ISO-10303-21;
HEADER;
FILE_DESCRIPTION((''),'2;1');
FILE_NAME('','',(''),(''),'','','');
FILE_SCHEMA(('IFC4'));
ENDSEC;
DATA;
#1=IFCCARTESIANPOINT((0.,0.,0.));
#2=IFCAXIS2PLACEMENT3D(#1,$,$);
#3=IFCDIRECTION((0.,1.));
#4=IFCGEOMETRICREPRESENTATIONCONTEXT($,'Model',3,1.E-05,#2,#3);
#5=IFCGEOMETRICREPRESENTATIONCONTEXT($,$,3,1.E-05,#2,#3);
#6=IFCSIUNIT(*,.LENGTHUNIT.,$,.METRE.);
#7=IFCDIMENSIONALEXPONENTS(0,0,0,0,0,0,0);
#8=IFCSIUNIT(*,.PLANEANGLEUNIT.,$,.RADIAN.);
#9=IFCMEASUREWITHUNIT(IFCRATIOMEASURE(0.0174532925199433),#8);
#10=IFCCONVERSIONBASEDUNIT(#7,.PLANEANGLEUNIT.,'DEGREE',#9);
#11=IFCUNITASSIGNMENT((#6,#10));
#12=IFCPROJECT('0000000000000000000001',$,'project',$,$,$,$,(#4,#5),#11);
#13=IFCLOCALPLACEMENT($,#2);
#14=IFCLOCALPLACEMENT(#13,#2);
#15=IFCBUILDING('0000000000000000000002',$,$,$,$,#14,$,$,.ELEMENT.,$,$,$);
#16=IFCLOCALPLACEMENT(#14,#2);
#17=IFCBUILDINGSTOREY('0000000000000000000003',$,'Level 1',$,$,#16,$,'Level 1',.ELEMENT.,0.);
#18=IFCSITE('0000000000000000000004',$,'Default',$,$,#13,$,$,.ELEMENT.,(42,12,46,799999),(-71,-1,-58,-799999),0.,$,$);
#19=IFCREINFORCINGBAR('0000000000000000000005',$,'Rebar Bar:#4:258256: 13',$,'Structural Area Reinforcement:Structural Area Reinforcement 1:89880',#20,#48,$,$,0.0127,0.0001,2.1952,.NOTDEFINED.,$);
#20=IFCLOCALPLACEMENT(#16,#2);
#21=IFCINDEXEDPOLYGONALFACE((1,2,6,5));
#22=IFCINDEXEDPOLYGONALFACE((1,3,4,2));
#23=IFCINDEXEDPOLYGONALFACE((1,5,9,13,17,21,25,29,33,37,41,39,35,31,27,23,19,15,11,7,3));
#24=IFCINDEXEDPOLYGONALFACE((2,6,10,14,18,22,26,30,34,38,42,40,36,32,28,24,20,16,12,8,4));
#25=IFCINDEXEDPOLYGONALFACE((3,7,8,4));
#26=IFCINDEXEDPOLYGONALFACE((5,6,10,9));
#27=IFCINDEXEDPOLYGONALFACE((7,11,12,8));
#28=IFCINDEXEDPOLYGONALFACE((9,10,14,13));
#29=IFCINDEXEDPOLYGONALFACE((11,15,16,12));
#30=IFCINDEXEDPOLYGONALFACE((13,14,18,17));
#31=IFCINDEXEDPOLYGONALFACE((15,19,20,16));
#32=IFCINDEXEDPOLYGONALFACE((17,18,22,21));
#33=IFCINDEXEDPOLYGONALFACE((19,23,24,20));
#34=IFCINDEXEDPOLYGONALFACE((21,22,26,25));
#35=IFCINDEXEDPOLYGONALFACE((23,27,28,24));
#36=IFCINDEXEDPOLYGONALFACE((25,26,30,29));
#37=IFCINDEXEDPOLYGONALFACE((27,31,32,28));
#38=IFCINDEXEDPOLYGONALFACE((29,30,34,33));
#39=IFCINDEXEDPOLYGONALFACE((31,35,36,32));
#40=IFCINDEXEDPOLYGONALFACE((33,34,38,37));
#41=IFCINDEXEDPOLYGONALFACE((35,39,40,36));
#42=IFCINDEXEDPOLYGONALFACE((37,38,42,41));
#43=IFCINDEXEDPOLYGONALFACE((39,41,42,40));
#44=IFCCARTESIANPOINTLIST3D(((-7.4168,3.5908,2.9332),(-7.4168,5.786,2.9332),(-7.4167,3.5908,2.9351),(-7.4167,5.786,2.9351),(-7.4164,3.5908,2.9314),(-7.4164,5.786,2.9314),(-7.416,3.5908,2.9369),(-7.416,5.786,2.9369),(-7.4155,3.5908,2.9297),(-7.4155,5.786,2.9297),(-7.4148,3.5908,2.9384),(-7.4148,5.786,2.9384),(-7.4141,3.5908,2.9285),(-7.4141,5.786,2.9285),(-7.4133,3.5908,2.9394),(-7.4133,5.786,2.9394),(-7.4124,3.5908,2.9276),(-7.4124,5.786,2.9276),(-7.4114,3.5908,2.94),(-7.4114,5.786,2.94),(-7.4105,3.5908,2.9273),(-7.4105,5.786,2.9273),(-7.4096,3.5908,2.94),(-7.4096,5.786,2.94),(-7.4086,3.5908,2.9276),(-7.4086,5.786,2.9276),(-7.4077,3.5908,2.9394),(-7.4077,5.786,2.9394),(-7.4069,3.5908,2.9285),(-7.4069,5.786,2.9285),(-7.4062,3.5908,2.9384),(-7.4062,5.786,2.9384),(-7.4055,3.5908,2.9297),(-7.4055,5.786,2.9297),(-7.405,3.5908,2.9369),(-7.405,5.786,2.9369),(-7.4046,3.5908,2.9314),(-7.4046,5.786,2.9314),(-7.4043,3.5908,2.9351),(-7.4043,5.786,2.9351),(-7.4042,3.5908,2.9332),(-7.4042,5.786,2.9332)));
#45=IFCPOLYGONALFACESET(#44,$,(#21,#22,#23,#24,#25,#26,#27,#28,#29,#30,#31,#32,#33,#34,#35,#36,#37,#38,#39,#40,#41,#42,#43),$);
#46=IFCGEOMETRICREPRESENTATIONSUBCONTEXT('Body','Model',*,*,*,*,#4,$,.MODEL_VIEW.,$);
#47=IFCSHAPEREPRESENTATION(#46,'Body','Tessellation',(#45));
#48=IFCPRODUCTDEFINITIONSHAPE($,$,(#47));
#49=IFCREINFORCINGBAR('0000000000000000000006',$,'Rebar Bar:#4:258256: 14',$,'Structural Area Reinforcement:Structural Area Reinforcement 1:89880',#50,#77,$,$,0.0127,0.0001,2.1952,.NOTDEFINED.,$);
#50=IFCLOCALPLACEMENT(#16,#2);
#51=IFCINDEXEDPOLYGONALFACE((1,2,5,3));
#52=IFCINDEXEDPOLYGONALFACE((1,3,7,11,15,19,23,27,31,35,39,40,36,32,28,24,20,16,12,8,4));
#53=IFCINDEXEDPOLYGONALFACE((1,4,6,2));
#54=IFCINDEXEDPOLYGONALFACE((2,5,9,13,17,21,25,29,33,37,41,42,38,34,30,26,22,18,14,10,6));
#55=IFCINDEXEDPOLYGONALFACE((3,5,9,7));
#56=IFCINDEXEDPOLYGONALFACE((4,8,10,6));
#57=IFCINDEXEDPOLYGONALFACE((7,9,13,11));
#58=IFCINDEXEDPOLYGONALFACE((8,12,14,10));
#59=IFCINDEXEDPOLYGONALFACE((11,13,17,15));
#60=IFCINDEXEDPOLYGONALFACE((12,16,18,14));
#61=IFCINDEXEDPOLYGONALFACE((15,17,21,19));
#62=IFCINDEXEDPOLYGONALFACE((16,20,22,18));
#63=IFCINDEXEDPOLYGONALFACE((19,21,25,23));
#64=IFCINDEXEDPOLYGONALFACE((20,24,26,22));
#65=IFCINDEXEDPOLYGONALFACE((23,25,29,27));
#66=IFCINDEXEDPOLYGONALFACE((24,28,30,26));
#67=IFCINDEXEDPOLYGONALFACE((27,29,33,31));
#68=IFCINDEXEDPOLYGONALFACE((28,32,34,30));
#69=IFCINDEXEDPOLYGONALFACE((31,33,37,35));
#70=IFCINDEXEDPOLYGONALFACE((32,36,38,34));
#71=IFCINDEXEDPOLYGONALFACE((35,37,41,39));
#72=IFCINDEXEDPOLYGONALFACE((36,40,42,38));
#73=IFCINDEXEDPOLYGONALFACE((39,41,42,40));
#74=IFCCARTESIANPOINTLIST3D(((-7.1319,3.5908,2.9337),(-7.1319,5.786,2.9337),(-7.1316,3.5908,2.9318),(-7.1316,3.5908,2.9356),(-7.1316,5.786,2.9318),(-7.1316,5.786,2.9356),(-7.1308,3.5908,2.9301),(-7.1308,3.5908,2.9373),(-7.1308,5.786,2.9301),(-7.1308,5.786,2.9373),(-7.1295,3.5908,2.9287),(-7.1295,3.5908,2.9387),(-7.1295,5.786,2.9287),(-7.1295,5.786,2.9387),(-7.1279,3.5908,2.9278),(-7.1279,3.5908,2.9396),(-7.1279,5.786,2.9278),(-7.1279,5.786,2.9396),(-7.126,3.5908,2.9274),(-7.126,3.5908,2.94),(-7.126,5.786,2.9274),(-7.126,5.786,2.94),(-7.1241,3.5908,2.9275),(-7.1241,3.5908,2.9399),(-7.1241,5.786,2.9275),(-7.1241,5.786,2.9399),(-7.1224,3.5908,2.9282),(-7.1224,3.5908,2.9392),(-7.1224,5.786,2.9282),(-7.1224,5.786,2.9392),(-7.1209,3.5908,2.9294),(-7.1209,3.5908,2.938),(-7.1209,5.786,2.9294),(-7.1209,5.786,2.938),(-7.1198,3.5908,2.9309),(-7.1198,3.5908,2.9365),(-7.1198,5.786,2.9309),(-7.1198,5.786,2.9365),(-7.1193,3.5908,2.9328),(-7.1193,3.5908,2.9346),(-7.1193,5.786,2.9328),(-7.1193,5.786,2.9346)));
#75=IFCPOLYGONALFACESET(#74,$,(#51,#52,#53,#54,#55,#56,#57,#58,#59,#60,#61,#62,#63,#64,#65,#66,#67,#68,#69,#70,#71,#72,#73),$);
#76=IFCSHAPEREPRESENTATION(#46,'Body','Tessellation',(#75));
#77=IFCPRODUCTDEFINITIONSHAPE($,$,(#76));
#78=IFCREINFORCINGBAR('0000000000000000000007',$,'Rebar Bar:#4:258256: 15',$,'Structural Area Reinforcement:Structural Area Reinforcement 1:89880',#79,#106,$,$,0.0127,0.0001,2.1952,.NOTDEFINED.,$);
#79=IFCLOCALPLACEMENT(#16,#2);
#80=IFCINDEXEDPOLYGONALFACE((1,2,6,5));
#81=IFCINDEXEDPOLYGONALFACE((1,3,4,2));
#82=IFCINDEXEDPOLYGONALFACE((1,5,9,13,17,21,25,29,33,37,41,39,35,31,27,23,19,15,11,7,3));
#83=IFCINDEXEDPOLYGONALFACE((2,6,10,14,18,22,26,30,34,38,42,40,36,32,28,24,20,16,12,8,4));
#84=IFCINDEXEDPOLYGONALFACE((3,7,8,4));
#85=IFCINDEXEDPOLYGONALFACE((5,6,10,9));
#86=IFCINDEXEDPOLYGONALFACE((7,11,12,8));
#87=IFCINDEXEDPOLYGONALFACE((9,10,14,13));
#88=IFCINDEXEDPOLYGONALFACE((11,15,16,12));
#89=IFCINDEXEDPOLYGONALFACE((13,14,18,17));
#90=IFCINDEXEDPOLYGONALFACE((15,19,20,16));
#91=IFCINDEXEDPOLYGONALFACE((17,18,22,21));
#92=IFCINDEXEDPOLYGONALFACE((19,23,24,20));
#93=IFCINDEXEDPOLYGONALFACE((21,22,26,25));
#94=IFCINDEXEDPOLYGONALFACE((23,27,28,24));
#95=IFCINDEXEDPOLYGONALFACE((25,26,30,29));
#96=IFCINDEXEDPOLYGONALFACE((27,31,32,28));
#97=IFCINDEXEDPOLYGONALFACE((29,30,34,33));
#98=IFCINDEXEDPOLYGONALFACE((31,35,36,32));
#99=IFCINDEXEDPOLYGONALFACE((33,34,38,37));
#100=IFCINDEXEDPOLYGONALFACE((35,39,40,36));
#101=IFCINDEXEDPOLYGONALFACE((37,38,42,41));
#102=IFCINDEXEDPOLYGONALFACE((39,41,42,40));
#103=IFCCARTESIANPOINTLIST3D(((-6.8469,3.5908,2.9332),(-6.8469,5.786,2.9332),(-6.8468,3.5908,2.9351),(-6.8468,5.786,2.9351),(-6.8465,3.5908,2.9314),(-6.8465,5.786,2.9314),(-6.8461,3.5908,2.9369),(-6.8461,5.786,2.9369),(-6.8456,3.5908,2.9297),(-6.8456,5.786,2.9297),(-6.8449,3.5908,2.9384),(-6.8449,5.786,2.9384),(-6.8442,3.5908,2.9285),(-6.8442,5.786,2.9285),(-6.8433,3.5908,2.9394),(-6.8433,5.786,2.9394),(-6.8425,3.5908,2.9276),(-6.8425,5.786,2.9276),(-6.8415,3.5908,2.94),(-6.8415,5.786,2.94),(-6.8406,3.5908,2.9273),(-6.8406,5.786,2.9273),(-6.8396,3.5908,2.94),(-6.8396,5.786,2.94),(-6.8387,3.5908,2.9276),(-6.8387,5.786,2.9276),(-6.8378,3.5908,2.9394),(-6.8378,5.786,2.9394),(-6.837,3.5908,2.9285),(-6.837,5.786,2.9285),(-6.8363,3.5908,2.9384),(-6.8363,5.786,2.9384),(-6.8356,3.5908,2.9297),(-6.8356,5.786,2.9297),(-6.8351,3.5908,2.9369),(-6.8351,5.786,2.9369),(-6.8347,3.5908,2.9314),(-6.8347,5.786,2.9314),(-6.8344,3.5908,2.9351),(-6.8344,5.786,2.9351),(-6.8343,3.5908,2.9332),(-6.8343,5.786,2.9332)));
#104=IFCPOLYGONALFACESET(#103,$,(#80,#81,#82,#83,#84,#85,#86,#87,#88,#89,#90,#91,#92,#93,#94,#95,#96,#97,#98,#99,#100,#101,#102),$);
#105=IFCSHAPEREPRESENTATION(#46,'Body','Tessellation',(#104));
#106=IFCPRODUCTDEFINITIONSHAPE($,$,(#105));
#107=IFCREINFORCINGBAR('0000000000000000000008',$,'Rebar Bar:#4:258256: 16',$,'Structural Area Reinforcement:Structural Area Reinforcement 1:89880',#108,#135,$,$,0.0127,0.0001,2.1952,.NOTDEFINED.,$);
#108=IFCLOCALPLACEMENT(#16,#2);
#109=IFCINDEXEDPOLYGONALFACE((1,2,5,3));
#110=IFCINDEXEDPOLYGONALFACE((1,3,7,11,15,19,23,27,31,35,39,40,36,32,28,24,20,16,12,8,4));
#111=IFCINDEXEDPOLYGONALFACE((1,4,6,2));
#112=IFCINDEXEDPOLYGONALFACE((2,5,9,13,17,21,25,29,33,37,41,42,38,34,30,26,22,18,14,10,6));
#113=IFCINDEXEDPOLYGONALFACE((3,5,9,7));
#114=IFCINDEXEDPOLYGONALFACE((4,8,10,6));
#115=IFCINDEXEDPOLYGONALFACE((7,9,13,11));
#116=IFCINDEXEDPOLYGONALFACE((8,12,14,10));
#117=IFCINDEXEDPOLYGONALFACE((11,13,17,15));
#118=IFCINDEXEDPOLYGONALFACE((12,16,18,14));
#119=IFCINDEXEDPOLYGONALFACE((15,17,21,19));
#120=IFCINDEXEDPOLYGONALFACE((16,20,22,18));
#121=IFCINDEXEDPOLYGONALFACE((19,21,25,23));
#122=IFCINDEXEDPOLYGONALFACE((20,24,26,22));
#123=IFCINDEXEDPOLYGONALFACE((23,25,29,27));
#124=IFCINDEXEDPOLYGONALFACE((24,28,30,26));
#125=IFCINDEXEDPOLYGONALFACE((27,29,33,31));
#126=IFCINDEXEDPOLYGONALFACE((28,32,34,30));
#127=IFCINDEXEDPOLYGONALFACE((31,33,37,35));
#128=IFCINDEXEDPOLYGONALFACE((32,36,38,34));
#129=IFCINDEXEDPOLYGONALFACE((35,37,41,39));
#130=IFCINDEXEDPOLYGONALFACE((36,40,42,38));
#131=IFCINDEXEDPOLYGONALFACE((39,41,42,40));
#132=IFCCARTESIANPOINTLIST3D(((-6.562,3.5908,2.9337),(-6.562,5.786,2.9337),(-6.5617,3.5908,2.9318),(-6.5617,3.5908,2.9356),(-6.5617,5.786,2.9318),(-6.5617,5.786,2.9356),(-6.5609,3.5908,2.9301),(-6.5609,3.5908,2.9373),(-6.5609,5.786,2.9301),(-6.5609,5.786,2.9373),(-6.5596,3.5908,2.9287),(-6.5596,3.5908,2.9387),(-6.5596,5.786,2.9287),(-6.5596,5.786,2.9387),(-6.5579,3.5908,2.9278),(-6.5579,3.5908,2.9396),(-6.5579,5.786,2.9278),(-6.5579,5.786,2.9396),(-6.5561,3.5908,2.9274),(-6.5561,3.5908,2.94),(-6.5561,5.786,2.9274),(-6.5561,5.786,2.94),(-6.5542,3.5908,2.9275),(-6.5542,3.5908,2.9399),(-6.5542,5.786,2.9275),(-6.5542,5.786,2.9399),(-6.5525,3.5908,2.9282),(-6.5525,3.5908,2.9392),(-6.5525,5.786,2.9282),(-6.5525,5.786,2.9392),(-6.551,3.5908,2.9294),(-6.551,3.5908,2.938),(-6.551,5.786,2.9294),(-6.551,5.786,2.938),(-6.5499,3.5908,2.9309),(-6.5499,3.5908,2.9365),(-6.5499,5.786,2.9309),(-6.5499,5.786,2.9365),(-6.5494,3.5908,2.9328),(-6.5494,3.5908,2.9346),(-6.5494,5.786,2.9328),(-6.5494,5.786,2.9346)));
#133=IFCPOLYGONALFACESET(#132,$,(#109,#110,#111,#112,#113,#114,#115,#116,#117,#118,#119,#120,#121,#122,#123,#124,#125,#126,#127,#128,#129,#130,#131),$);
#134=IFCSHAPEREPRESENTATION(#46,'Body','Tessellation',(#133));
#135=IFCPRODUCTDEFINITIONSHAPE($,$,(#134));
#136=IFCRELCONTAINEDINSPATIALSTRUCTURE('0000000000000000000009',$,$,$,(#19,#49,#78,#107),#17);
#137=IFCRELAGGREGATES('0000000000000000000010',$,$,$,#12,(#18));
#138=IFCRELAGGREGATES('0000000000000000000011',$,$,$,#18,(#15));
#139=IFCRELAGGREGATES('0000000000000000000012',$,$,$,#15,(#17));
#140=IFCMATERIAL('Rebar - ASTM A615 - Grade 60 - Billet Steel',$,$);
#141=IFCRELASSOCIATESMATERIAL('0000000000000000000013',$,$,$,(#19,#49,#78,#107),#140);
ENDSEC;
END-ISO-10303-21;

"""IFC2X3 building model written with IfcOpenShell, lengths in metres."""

from ifc_helpers import new_model, entity, si_unit, converted_unit, direction, origin, place, context, subcontext, project, spatial, material, element, save


model = new_model("IFC2X3")

# Units and contexts
model_context = context("Model", 3, precision=1e-05, world=origin(), true_north=direction((0.0, 1.0)))
context_of_model = context(None, 3, precision=1e-05, world=origin(), true_north=direction((0.0, 1.0)))
body_context = subcontext(model_context, "Body", "Model", "MODEL_VIEW")
ifc_project = project(units=[si_unit("LENGTHUNIT", "METRE"), converted_unit("PLANEANGLEUNIT", "DEGREE", entity("IfcRatioMeasure", 0.0174532925199433), si_unit("PLANEANGLEUNIT", "RADIAN"), dimensions=[0, 0, 0, 0, 0, 0, 0])], contexts=[model_context, context_of_model])

# Site, building, storey
site_placement = place(None, origin())
site = spatial("IfcSite", under=ifc_project, at=site_placement, Name="Default", CompositionType="ELEMENT", RefLatitude=(42, 12, 46, 799999), RefLongitude=(-71, -1, -58, -799999), RefElevation=0.0)
building_placement = place(site_placement, origin())
building = spatial("IfcBuilding", under=site, at=building_placement, CompositionType="ELEMENT")
storey_placement = place(building_placement, origin())
storey = spatial("IfcBuildingStorey", under=building, at=storey_placement, Name="Level 1", LongName="Level 1", CompositionType="ELEMENT", Elevation=0.0)

# Shared definitions
ifc_material_1 = material(Name="Rebar - ASTM A615 - Grade 60 - Billet Steel")

# Reinforcing bars
reinforcing_bar_1_placement = place(storey_placement, origin())
element("IfcReinforcingBar", 1, at=reinforcing_bar_1_placement, inside=storey, material=ifc_material_1, Name="Rebar Bar:#4:258256: 13", ObjectType="Structural Area Reinforcement:Structural Area Reinforcement 1:89880", BarLength=2.1952, BarRole="NOTDEFINED", CrossSectionArea=0.0001, NominalDiameter=0.0127, context=body_context, shape_type="AdvancedSweptSolid", body=[
    entity("IfcSweptDiskSolid", entity("IfcCompositeCurve", [entity("IfcCompositeCurveSegment", "CONTINUOUS", True, entity("IfcPolyline", [entity("IfcCartesianPoint", [-7.4105, 5.786, 2.9337]), entity("IfcCartesianPoint", [-7.4105, 3.5908, 2.9337])]))], False), 0.0063, None, 0.0, 1.0),
])
reinforcing_bar_2_placement = place(storey_placement, origin())
element("IfcReinforcingBar", 2, at=reinforcing_bar_2_placement, inside=storey, material=ifc_material_1, Name="Rebar Bar:#4:258256: 14", ObjectType="Structural Area Reinforcement:Structural Area Reinforcement 1:89880", BarLength=2.1952, BarRole="NOTDEFINED", CrossSectionArea=0.0001, NominalDiameter=0.0127, context=body_context, shape_type="AdvancedSweptSolid", body=[
    entity("IfcSweptDiskSolid", entity("IfcCompositeCurve", [entity("IfcCompositeCurveSegment", "CONTINUOUS", True, entity("IfcPolyline", [entity("IfcCartesianPoint", [-7.1255, 5.786, 2.9337]), entity("IfcCartesianPoint", [-7.1255, 3.5908, 2.9337])]))], False), 0.0063, None, 0.0, 1.0),
])
reinforcing_bar_3_placement = place(storey_placement, origin())
element("IfcReinforcingBar", 3, at=reinforcing_bar_3_placement, inside=storey, material=ifc_material_1, Name="Rebar Bar:#4:258256: 15", ObjectType="Structural Area Reinforcement:Structural Area Reinforcement 1:89880", BarLength=2.1952, BarRole="NOTDEFINED", CrossSectionArea=0.0001, NominalDiameter=0.0127, context=body_context, shape_type="AdvancedSweptSolid", body=[
    entity("IfcSweptDiskSolid", entity("IfcCompositeCurve", [entity("IfcCompositeCurveSegment", "CONTINUOUS", True, entity("IfcPolyline", [entity("IfcCartesianPoint", [-6.8406, 5.786, 2.9337]), entity("IfcCartesianPoint", [-6.8406, 3.5908, 2.9337])]))], False), 0.0063, None, 0.0, 1.0),
])
reinforcing_bar_4_placement = place(storey_placement, origin())
element("IfcReinforcingBar", 4, at=reinforcing_bar_4_placement, inside=storey, material=ifc_material_1, Name="Rebar Bar:#4:258256: 16", ObjectType="Structural Area Reinforcement:Structural Area Reinforcement 1:89880", BarLength=2.1952, BarRole="NOTDEFINED", CrossSectionArea=0.0001, NominalDiameter=0.0127, context=body_context, shape_type="AdvancedSweptSolid", body=[
    entity("IfcSweptDiskSolid", entity("IfcCompositeCurve", [entity("IfcCompositeCurveSegment", "CONTINUOUS", True, entity("IfcPolyline", [entity("IfcCartesianPoint", [-6.5556, 5.786, 2.9337]), entity("IfcCartesianPoint", [-6.5556, 3.5908, 2.9337])]))], False), 0.0063, None, 0.0, 1.0),
])

save(model, "model.ifc")
